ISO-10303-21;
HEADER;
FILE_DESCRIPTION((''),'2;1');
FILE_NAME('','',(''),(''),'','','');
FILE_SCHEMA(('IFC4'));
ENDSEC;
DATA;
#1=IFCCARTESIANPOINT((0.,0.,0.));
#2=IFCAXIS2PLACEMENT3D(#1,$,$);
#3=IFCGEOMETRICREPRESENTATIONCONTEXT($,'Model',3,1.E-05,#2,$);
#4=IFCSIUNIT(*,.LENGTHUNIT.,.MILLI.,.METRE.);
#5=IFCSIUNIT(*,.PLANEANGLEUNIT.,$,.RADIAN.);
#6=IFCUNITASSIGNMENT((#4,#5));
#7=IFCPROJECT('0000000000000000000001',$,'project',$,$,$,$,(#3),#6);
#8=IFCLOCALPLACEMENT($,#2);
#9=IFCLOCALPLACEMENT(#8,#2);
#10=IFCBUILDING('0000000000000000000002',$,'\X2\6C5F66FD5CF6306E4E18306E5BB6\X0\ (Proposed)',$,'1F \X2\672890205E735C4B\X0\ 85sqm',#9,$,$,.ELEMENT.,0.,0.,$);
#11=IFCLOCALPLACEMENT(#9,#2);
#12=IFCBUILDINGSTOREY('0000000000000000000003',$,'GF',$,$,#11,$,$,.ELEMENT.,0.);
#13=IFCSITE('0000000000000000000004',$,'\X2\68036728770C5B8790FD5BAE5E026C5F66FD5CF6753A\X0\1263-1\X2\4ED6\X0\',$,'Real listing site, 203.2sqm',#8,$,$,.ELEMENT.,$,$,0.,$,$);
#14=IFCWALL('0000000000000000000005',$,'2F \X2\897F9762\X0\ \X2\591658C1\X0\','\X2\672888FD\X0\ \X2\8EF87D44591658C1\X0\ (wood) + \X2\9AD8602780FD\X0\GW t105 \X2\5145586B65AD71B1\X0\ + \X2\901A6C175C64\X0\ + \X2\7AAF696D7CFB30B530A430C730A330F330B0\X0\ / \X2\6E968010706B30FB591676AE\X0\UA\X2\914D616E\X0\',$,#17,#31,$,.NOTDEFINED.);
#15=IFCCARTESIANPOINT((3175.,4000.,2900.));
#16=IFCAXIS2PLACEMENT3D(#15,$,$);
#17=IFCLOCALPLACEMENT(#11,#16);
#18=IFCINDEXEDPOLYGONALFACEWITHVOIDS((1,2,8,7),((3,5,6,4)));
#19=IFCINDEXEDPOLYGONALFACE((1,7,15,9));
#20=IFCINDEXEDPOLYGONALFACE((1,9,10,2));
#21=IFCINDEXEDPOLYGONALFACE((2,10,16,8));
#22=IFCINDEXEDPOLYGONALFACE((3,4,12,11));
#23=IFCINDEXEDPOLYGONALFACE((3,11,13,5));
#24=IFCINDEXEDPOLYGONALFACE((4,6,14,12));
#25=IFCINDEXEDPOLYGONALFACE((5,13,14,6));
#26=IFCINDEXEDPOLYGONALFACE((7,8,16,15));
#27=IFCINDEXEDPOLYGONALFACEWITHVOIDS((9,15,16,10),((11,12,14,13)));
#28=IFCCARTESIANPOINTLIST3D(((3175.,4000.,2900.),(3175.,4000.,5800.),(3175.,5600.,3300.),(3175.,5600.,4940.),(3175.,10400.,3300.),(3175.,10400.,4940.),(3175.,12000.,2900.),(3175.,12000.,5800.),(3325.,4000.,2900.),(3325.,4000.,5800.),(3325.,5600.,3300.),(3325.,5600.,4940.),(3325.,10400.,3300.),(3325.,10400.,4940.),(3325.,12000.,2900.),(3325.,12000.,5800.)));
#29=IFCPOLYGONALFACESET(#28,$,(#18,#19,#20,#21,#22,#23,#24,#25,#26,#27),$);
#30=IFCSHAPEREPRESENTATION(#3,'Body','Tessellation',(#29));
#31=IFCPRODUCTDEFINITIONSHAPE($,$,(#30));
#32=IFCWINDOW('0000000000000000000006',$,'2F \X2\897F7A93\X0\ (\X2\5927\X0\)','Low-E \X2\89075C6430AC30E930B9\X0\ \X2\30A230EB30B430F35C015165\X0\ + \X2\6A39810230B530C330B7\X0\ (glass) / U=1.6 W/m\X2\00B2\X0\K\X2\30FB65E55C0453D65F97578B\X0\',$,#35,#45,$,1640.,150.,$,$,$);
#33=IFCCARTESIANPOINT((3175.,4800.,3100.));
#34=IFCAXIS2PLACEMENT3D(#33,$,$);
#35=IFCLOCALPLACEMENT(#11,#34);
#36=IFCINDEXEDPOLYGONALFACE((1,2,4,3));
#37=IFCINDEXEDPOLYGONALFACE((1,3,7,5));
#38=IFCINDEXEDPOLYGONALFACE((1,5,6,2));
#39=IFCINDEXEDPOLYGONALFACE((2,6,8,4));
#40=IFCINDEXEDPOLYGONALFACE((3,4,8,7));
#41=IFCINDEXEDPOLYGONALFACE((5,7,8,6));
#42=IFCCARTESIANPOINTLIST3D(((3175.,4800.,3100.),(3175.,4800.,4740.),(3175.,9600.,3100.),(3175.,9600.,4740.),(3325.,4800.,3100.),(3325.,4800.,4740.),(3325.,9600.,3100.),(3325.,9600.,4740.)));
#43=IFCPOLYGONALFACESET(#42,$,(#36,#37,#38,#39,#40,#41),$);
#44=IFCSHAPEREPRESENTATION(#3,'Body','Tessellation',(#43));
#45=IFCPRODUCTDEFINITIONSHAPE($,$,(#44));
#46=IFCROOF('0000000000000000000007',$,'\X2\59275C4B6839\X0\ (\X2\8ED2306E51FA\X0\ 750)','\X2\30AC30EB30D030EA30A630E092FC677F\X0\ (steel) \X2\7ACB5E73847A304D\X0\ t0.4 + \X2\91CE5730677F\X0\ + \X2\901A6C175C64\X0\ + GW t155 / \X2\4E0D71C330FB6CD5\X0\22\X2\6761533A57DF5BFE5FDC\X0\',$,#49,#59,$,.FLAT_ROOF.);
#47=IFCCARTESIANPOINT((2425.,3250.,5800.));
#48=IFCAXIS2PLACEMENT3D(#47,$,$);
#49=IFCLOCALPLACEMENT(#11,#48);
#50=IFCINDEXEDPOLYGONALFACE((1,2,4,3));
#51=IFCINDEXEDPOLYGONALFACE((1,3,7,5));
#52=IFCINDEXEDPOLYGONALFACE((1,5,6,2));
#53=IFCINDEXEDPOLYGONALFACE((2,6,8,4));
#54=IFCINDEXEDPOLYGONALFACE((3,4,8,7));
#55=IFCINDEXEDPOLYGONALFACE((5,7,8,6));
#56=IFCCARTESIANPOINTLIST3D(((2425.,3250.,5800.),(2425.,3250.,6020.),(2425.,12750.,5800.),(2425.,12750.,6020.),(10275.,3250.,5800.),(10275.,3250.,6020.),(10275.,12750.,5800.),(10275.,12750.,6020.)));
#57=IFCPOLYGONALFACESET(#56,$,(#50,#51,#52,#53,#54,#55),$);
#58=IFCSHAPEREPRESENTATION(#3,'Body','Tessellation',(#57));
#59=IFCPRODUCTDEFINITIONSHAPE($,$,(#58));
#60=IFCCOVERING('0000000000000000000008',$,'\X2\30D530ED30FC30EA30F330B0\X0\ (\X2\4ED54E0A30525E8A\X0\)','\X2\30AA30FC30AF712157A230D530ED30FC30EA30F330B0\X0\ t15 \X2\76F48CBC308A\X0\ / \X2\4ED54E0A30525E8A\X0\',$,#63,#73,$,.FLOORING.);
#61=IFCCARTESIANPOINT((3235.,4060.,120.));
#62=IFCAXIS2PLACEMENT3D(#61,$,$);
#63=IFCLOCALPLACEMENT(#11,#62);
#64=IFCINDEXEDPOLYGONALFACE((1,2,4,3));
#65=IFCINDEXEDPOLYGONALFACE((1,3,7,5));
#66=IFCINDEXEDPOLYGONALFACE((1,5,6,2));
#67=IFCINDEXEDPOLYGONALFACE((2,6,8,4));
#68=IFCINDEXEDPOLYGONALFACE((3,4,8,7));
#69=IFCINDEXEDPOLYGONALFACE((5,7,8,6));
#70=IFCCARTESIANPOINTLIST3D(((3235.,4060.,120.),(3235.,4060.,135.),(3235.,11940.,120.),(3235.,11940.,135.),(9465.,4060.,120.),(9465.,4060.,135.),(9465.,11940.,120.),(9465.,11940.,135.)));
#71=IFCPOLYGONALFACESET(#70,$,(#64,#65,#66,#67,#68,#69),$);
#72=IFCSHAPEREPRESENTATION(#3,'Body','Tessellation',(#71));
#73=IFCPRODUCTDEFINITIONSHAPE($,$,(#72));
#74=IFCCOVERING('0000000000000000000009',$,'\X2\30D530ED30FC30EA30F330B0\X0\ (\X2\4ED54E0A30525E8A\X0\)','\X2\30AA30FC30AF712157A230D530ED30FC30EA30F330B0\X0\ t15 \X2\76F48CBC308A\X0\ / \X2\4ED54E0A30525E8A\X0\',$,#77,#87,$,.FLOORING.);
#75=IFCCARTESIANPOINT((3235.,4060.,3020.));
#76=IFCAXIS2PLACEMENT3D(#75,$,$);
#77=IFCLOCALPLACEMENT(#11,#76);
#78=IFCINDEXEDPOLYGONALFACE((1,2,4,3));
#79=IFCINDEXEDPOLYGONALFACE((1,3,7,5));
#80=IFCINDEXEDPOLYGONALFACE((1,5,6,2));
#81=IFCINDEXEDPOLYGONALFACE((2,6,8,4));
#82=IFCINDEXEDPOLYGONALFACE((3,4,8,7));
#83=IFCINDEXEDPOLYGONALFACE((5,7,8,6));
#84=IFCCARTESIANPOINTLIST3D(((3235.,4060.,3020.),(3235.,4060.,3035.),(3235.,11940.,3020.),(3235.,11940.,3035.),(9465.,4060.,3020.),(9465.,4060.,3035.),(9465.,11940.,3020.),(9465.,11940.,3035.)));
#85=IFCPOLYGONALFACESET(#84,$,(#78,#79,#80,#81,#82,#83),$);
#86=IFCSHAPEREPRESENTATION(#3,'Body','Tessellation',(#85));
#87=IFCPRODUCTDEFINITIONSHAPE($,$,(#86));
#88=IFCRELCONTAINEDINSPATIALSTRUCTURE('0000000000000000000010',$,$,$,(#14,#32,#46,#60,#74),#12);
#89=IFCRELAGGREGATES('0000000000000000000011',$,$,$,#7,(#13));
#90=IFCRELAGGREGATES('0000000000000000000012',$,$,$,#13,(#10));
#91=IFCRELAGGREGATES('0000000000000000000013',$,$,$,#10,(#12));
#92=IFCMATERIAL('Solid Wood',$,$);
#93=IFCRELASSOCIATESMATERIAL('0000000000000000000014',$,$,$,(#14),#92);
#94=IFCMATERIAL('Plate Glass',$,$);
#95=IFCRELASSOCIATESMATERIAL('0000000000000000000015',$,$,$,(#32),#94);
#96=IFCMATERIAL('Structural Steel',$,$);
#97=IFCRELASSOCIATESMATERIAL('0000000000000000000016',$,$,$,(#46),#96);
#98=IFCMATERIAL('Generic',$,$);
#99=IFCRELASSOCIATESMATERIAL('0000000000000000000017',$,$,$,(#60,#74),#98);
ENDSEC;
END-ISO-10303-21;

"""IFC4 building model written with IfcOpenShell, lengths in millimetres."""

from ifc_helpers import new_model, si_unit, frame, frame_2d, origin, place, context, project, spatial, rectangle, extrude, material, element, fill, save


model = new_model("IFC4")

# Units and contexts
model_context = context("Model", 3, precision=1e-05, world=origin())
ifc_project = project(units=[si_unit("LENGTHUNIT", "METRE", prefix="MILLI"), si_unit("PLANEANGLEUNIT", "RADIAN")], contexts=[model_context])

# Site, building, storey
site_placement = place(None, origin())
site = spatial("IfcSite", under=ifc_project, at=site_placement, Name="栃木県宇都宮市江曽島町1263-1他", ObjectType="Real listing site, 203.2sqm", CompositionType="ELEMENT", RefElevation=0.0)
building_placement = place(site_placement, origin())
building = spatial("IfcBuilding", under=site, at=building_placement, Name="江曽島の丘の家 (Proposed)", ObjectType="1F 木造平屋 85sqm", CompositionType="ELEMENT", ElevationOfRefHeight=0.0, ElevationOfTerrain=0.0)
storey_placement = place(building_placement, origin())
storey = spatial("IfcBuildingStorey", under=building, at=storey_placement, Name="GF", CompositionType="ELEMENT", Elevation=0.0)

# Shared definitions
ifc_material_1 = material(Name="Solid Wood")
ifc_material_2 = material(Name="Generic")

# Shared definitions
ifc_material_3 = material(Name="Plate Glass")

# Wall, opening, window
wall_1_placement = place(storey_placement, frame((3175.0, 4000.0, 2900.0)))
wall_1 = element("IfcWall", 1, at=wall_1_placement, inside=storey, material=ifc_material_1, Name="2F 西面 外壁", Description="木製 軸組外壁 (wood) + 高性能GW t105 充填断熱 + 通気層 + 窯業系サイディング / 準耐火・外皮UA配慮", PredefinedType="NOTDEFINED", context=model_context, shape_type="SweptSolid", body=[
    extrude(rectangle(XDim=150.0, YDim=8000.0, at=frame_2d((75.0, 4000.0))), frame((3175.0, 4000.0, 2900.0)), (0.0, 0.0, 1.0), 2900.0),
])
opening_1_placement = place(storey_placement, frame((3175.0, 4800.0, 3100.0)))
opening_1 = element("IfcOpeningElement", 2, at=opening_1_placement, cuts=wall_1, PredefinedType="NOTDEFINED", context=model_context, shape_type="SweptSolid", body=[
    extrude(rectangle(XDim=150.0, YDim=4800.0, at=frame_2d((75.0, 2400.0))), frame((3175.0, 4800.0, 3100.0)), (0.0, 0.0, 1.0), 1640.0),
])
window_1_placement = place(storey_placement, frame((3175.0, 4800.0, 3100.0)))
window_1 = element("IfcWindow", 3, at=window_1_placement, inside=storey, material=ifc_material_3, Name="2F 西窓 (大)", Description="Low-E 複層ガラス アルゴン封入 + 樹脂サッシ (glass) / U=1.6 W/m²K・日射取得型", OverallHeight=1640.0, OverallWidth=150.0, context=model_context, shape_type="SweptSolid", body=[
    extrude(rectangle(XDim=150.0, YDim=4800.0, at=frame_2d((75.0, 2400.0))), frame((3175.0, 4800.0, 3100.0)), (0.0, 0.0, 1.0), 1640.0),
])
fill(opening_1, window_1)

# Roof
ifc_material_4 = material(Name="Structural Steel")
roof_placement = place(storey_placement, frame((2425.0, 3250.0, 5800.0)))
element("IfcRoof", 4, at=roof_placement, inside=storey, material=ifc_material_4, Name="大屋根 (軒の出 750)", Description="ガルバリウム鋼板 (steel) 立平葺き t0.4 + 野地板 + 通気層 + GW t155 / 不燃・法22条区域対応", PredefinedType="FLAT_ROOF", context=model_context, shape_type="SweptSolid", body=[
    extrude(rectangle(XDim=7850.0, YDim=9500.0, at=frame_2d((3925.0, 4750.0))), frame((2425.0, 3250.0, 5800.0)), (0.0, 0.0, 1.0), 220.0),
])

# Coverings
covering_1_placement = place(storey_placement, frame((3235.0, 4060.0, 120.0)))
element("IfcCovering", 5, at=covering_1_placement, inside=storey, material=ifc_material_2, Name="フローリング (仕上げ床)", Description="オーク無垢フローリング t15 直貼り / 仕上げ床", PredefinedType="FLOORING", context=model_context, shape_type="SweptSolid", body=[
    extrude(rectangle(XDim=6230.0, YDim=7880.0, at=frame_2d((3115.0, 3940.0))), frame((3235.0, 4060.0, 120.0)), (0.0, 0.0, 1.0), 15.0),
])
covering_2_placement = place(storey_placement, frame((3235.0, 4060.0, 3020.0)))
element("IfcCovering", 6, at=covering_2_placement, inside=storey, material=ifc_material_2, Name="フローリング (仕上げ床)", Description="オーク無垢フローリング t15 直貼り / 仕上げ床", PredefinedType="FLOORING", context=model_context, shape_type="SweptSolid", body=[
    extrude(rectangle(XDim=6230.0, YDim=7880.0, at=frame_2d((3115.0, 3940.0))), frame((3235.0, 4060.0, 3020.0)), (0.0, 0.0, 1.0), 15.0),
])

save(model, "model.ifc")
